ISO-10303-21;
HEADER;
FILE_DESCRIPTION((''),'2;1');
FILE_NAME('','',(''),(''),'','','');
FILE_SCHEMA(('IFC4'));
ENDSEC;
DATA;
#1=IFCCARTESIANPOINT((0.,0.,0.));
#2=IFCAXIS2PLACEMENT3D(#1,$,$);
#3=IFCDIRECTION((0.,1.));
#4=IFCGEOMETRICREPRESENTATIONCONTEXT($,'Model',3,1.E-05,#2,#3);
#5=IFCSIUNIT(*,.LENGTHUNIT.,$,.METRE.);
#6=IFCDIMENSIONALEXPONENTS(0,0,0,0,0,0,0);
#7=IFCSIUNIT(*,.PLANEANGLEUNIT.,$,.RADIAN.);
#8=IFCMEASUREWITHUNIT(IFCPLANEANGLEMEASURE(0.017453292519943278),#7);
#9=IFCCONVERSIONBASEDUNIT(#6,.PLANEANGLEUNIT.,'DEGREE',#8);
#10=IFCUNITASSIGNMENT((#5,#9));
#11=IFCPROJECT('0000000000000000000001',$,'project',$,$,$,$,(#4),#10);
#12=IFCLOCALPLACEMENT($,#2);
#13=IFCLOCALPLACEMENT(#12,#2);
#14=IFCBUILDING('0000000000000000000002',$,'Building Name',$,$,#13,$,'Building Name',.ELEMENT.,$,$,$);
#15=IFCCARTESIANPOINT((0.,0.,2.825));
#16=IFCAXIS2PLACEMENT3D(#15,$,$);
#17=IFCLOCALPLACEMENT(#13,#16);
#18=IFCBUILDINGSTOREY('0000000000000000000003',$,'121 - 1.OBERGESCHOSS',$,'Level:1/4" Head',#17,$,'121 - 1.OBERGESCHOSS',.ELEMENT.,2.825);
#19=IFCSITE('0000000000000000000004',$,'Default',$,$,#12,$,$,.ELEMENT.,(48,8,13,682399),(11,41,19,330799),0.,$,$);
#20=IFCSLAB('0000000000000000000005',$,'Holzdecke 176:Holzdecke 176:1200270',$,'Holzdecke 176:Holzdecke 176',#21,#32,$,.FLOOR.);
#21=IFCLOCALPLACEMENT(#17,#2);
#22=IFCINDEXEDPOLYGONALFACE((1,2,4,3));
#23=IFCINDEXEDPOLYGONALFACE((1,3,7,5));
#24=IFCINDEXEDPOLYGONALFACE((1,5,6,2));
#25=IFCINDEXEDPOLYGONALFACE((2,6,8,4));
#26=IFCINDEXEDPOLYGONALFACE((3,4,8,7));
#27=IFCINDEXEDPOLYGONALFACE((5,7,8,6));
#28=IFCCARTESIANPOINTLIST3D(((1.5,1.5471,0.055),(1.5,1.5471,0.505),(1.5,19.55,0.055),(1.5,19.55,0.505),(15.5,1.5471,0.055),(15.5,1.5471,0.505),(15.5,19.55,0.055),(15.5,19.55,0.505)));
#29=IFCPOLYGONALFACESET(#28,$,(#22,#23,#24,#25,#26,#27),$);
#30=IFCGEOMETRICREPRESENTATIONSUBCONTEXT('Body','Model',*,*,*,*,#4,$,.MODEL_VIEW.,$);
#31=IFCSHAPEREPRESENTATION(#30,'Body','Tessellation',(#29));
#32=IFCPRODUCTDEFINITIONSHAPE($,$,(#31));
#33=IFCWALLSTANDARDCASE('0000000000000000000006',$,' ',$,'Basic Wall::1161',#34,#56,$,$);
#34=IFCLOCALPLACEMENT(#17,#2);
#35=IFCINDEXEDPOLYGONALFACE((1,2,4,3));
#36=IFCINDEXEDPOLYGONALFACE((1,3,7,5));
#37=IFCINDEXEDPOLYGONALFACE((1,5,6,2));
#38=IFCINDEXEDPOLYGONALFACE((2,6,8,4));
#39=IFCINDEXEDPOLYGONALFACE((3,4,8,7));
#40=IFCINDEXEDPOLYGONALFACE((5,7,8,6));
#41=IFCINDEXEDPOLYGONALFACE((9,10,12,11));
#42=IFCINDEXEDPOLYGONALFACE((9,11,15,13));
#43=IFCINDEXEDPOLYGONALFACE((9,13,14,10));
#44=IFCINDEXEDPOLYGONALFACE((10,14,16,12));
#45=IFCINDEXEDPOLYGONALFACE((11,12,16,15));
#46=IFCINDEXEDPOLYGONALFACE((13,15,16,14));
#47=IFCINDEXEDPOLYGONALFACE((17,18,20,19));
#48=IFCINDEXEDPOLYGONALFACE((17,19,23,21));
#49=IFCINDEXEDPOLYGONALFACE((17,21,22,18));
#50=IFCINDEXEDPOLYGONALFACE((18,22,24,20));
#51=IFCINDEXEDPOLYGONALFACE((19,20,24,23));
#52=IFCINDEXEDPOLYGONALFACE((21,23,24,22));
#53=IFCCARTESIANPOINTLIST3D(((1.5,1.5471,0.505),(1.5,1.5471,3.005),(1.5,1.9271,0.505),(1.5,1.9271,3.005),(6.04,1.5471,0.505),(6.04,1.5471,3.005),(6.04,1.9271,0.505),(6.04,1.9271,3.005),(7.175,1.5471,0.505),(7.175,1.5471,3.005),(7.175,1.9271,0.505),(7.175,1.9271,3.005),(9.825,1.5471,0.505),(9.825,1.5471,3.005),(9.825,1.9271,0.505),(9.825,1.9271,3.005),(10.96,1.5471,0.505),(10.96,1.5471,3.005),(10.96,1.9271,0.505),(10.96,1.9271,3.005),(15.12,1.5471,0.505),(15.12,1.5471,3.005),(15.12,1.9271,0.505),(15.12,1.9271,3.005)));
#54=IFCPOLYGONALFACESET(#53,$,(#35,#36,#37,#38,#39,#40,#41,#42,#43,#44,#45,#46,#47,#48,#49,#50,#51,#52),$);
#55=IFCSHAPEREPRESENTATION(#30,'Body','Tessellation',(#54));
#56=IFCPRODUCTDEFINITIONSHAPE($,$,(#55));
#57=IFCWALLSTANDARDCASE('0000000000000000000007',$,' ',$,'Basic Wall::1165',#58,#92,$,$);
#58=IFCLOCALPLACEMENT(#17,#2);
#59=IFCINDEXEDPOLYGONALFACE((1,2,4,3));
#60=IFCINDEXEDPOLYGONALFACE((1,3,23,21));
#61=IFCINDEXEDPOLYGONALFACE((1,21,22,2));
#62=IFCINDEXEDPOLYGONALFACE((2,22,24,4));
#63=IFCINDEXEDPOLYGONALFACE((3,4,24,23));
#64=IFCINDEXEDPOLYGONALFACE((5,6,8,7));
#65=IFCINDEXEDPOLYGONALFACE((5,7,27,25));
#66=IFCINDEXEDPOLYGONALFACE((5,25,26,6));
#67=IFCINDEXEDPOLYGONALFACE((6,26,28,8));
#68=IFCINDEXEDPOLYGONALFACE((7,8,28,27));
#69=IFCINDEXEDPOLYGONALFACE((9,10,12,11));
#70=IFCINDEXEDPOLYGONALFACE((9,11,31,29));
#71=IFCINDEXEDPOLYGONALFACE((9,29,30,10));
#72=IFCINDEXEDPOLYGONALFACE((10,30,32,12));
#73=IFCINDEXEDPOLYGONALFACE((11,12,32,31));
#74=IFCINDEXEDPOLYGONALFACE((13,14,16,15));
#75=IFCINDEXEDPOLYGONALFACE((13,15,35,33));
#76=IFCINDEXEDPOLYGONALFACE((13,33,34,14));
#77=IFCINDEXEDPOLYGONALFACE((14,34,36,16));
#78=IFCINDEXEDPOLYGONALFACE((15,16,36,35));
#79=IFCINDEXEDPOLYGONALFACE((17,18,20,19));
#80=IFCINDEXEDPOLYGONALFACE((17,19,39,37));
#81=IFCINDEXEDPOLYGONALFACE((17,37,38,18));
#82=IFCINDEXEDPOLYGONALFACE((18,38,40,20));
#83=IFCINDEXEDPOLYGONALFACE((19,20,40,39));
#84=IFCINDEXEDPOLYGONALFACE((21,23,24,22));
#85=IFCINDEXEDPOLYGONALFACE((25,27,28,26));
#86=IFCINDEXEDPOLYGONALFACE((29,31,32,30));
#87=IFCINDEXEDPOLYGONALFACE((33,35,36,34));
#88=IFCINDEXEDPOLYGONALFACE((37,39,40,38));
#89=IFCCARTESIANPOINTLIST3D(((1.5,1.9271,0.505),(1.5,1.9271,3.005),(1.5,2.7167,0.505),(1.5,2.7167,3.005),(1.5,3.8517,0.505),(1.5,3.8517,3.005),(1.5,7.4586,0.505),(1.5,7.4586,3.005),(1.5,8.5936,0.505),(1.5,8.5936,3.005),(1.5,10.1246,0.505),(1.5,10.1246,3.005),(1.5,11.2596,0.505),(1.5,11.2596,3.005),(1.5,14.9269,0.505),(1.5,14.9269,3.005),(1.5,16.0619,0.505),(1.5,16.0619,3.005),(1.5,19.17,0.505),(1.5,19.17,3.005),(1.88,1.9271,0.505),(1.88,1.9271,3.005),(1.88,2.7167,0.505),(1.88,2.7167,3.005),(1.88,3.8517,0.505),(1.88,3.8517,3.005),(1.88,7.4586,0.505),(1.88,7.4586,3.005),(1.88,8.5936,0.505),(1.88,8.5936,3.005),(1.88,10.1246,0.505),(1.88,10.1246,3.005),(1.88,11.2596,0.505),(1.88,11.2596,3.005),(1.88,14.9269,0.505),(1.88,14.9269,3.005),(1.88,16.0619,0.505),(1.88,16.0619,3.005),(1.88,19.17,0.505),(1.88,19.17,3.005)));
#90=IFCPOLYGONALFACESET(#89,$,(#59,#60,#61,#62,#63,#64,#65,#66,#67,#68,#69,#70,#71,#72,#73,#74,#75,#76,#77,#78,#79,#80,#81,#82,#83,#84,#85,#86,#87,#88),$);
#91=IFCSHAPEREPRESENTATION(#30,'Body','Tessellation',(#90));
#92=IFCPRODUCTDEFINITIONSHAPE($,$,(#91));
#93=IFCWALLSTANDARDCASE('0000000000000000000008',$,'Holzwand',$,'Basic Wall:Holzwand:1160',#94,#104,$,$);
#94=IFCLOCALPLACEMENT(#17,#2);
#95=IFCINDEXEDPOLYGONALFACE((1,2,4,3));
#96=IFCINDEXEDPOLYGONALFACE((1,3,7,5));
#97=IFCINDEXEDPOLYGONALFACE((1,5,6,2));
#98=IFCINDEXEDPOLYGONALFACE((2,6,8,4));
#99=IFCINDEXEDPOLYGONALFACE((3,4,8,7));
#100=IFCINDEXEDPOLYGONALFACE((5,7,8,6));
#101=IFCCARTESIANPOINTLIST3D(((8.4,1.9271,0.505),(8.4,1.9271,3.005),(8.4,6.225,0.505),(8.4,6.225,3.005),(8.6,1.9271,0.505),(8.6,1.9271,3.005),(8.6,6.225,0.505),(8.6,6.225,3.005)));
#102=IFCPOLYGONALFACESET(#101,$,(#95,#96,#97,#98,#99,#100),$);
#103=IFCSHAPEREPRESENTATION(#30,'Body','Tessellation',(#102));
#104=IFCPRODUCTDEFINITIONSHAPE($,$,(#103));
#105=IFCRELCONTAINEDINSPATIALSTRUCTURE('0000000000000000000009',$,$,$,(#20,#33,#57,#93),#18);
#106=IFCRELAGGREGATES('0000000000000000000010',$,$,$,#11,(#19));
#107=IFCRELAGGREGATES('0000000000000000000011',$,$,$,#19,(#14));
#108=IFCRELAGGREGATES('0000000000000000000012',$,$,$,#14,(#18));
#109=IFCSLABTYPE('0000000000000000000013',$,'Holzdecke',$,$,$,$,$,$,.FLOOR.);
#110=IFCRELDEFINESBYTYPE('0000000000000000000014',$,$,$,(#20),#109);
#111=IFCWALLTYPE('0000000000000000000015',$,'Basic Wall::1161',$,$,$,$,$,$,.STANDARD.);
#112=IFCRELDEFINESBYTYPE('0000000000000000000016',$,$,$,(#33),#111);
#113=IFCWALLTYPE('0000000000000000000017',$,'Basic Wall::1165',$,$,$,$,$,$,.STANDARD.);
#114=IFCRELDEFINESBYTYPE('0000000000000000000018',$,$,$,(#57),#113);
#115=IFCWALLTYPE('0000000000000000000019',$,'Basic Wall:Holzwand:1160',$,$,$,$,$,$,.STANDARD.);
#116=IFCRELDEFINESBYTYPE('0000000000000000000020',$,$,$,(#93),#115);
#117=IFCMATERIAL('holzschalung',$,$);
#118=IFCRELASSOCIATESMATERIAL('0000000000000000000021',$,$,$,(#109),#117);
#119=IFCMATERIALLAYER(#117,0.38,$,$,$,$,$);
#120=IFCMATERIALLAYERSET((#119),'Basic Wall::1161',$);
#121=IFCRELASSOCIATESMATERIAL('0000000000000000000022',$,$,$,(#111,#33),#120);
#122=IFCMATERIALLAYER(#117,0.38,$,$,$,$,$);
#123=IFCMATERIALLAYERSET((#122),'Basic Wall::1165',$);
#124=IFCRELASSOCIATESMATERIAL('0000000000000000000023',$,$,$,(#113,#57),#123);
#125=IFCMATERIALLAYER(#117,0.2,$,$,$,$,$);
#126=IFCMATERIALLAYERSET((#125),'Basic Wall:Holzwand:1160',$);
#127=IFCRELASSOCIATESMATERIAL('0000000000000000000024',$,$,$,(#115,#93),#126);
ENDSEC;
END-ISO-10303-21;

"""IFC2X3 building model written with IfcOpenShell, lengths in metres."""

from ifc_helpers import new_model, entity, si_unit, converted_unit, direction, frame, frame_2d, origin, place, context, subcontext, project, spatial, rectangle, extrude, material, layer, layer_set, layer_usage, type_object, element, save


model = new_model("IFC2X3")

# Units and contexts
model_context = context("Model", 3, precision=1e-05, world=origin(), true_north=direction((0.0, 1.0)))
body_context = subcontext(model_context, "Body", "Model", "MODEL_VIEW")
ifc_project = project(units=[si_unit("LENGTHUNIT", "METRE"), converted_unit("PLANEANGLEUNIT", "DEGREE", entity("IfcPlaneAngleMeasure", 0.017453292519943278), si_unit("PLANEANGLEUNIT", "RADIAN"), dimensions=[0, 0, 0, 0, 0, 0, 0])], contexts=[model_context])

# Site, building, storey
site_placement = place(None, origin())
site = spatial("IfcSite", under=ifc_project, at=site_placement, Name="Default", CompositionType="ELEMENT", RefLatitude=(48, 8, 13, 682399), RefLongitude=(11, 41, 19, 330799), RefElevation=0.0)
building_placement = place(site_placement, origin())
building = spatial("IfcBuilding", under=site, at=building_placement, Name="Building Name", LongName="Building Name", CompositionType="ELEMENT")
storey_placement = place(building_placement, frame((0.0, 0.0, 2.825)))
storey = spatial("IfcBuildingStorey", under=building, at=storey_placement, Name="121 - 1.OBERGESCHOSS", ObjectType="Level:1/4\" Head", LongName="121 - 1.OBERGESCHOSS", CompositionType="ELEMENT", Elevation=2.825)

# Slab
ifc_material_1 = material(Name="holzschalung")
slab_type = type_object("IfcSlabType", Name="Holzdecke", PredefinedType="FLOOR", material=ifc_material_1)
slab_placement = place(storey_placement, origin())
element("IfcSlab", 1, at=slab_placement, inside=storey, type_object=slab_type, Name="Holzdecke 176:Holzdecke 176:1200270", ObjectType="Holzdecke 176:Holzdecke 176", PredefinedType="FLOOR", context=body_context, shape_type="SweptSolid", body=[
    extrude(rectangle(XDim=14.0, YDim=18.0029, at=frame_2d((0.0, 0.0), x_axis=(1.0, 0.0))), frame((8.5, 10.5486, 0.055), z_axis=(0.0, 0.0, 1.0), x_axis=(-1.0, 0.0, 0.0)), (0.0, 0.0, 1.0), 0.45),
])

# Walls, openings
ifc_layer_1 = layer(ifc_material_1, 0.38)
ifc_layer_set_1 = layer_set([ifc_layer_1], Name="Basic Wall::1161")
ifc_layer_usage_1 = layer_usage(ifc_layer_set_1, "AXIS2", "NEGATIVE", 0.19)
wall_type_1 = type_object("IfcWallType", Name="Basic Wall::1161", PredefinedType="STANDARD", material=ifc_layer_set_1)
wall_1_placement = place(storey_placement, frame((15.12, 1.7371, 0.505), z_axis=(0.0, 0.0, 1.0), x_axis=(-1.0, 0.0, 0.0)))
wall_1 = element("IfcWallStandardCase", 2, at=wall_1_placement, inside=storey, type_object=wall_type_1, material=ifc_layer_usage_1, Name=" ", ObjectType="Basic Wall::1161", context=body_context, shape_type="SweptSolid", body=[
    extrude(rectangle(XDim=13.62, YDim=0.38, at=frame_2d((6.81, 0.0), x_axis=(-1.0, 0.0))), origin(), (0.0, 0.0, 1.0), 2.5),
])
opening_1_placement = place(wall_1_placement, origin())
element("IfcOpeningElement", 3, at=opening_1_placement, cuts=wall_1, ObjectType="Opening", context=body_context, shape_type="SweptSolid", body=[
    extrude(rectangle(XDim=2.5, YDim=1.135, at=frame_2d((0.0, 0.0), x_axis=(1.0, 0.0))), frame((4.7275, -0.19, 1.25), z_axis=(0.0, 1.0, 0.0), x_axis=(0.0, 0.0, 1.0)), (0.0, 0.0, 1.0), 0.38),
])
opening_2_placement = place(wall_1_placement, origin())
element("IfcOpeningElement", 4, at=opening_2_placement, cuts=wall_1, ObjectType="Opening", context=body_context, shape_type="SweptSolid", body=[
    extrude(rectangle(XDim=2.5, YDim=1.135, at=frame_2d((0.0, 0.0), x_axis=(1.0, 0.0))), frame((8.5125, -0.19, 1.25), z_axis=(0.0, 1.0, 0.0), x_axis=(0.0, 0.0, 1.0)), (0.0, 0.0, 1.0), 0.38),
])
ifc_layer_2 = layer(ifc_material_1, 0.38)
ifc_layer_set_2 = layer_set([ifc_layer_2], Name="Basic Wall::1165")
ifc_layer_usage_2 = layer_usage(ifc_layer_set_2, "AXIS2", "NEGATIVE", 0.19)
wall_type_2 = type_object("IfcWallType", Name="Basic Wall::1165", PredefinedType="STANDARD", material=ifc_layer_set_2)
wall_2_placement = place(storey_placement, frame((1.69, 1.9271, 0.505), z_axis=(0.0, 0.0, 1.0), x_axis=(0.0, 1.0, 0.0)))
wall_2 = element("IfcWallStandardCase", 5, at=wall_2_placement, inside=storey, type_object=wall_type_2, material=ifc_layer_usage_2, Name=" ", ObjectType="Basic Wall::1165", context=body_context, shape_type="SweptSolid", body=[
    extrude(rectangle(XDim=17.2429, YDim=0.38, at=frame_2d((8.6214, 0.0), x_axis=(-1.0, 0.0))), origin(), (0.0, 0.0, 1.0), 2.5),
])
opening_3_placement = place(wall_2_placement, origin())
element("IfcOpeningElement", 6, at=opening_3_placement, cuts=wall_2, ObjectType="Opening", context=body_context, shape_type="SweptSolid", body=[
    extrude(rectangle(XDim=2.5, YDim=1.135, at=frame_2d((0.0, 0.0), x_axis=(1.0, 0.0))), frame((13.5673, -0.19, 1.25), z_axis=(0.0, 1.0, 0.0), x_axis=(0.0, 0.0, 1.0)), (0.0, 0.0, 1.0), 0.38),
])
opening_4_placement = place(wall_2_placement, origin())
element("IfcOpeningElement", 7, at=opening_4_placement, cuts=wall_2, ObjectType="Opening", context=body_context, shape_type="SweptSolid", body=[
    extrude(rectangle(XDim=2.5, YDim=1.135, at=frame_2d((0.0, 0.0), x_axis=(1.0, 0.0))), frame((8.765, -0.19, 1.25), z_axis=(0.0, 1.0, 0.0), x_axis=(0.0, 0.0, 1.0)), (0.0, 0.0, 1.0), 0.38),
])
opening_5_placement = place(wall_2_placement, origin())
element("IfcOpeningElement", 8, at=opening_5_placement, cuts=wall_2, ObjectType="Opening", context=body_context, shape_type="SweptSolid", body=[
    extrude(rectangle(XDim=2.5, YDim=1.135, at=frame_2d((0.0, 0.0), x_axis=(1.0, 0.0))), frame((6.0989, -0.19, 1.25), z_axis=(0.0, 1.0, 0.0), x_axis=(0.0, 0.0, 1.0)), (0.0, 0.0, 1.0), 0.38),
])
opening_6_placement = place(wall_2_placement, origin())
element("IfcOpeningElement", 9, at=opening_6_placement, cuts=wall_2, ObjectType="Opening", context=body_context, shape_type="SweptSolid", body=[
    extrude(rectangle(XDim=2.5, YDim=1.135, at=frame_2d((0.0, 0.0), x_axis=(1.0, 0.0))), frame((1.3571, -0.19, 1.25), z_axis=(0.0, 1.0, 0.0), x_axis=(0.0, 0.0, 1.0)), (0.0, 0.0, 1.0), 0.38),
])

# Wall
ifc_layer_3 = layer(ifc_material_1, 0.2)
ifc_layer_set_3 = layer_set([ifc_layer_3], Name="Basic Wall:Holzwand:1160")
ifc_layer_usage_3 = layer_usage(ifc_layer_set_3, "AXIS2", "NEGATIVE", 0.1)
wall_type_3 = type_object("IfcWallType", Name="Basic Wall:Holzwand:1160", PredefinedType="STANDARD", material=ifc_layer_set_3)
wall_3_placement = place(storey_placement, frame((8.5, 1.9271, 0.505), z_axis=(0.0, 0.0, 1.0), x_axis=(0.0, 1.0, 0.0)))
element("IfcWallStandardCase", 10, at=wall_3_placement, inside=storey, type_object=wall_type_3, material=ifc_layer_usage_3, Name="Holzwand", ObjectType="Basic Wall:Holzwand:1160", context=body_context, shape_type="SweptSolid", body=[
    extrude(rectangle(XDim=4.2979, YDim=0.2, at=frame_2d((2.1489, 0.0), x_axis=(-1.0, 0.0))), origin(), (0.0, 0.0, 1.0), 2.5),
])

save(model, "model.ifc")
